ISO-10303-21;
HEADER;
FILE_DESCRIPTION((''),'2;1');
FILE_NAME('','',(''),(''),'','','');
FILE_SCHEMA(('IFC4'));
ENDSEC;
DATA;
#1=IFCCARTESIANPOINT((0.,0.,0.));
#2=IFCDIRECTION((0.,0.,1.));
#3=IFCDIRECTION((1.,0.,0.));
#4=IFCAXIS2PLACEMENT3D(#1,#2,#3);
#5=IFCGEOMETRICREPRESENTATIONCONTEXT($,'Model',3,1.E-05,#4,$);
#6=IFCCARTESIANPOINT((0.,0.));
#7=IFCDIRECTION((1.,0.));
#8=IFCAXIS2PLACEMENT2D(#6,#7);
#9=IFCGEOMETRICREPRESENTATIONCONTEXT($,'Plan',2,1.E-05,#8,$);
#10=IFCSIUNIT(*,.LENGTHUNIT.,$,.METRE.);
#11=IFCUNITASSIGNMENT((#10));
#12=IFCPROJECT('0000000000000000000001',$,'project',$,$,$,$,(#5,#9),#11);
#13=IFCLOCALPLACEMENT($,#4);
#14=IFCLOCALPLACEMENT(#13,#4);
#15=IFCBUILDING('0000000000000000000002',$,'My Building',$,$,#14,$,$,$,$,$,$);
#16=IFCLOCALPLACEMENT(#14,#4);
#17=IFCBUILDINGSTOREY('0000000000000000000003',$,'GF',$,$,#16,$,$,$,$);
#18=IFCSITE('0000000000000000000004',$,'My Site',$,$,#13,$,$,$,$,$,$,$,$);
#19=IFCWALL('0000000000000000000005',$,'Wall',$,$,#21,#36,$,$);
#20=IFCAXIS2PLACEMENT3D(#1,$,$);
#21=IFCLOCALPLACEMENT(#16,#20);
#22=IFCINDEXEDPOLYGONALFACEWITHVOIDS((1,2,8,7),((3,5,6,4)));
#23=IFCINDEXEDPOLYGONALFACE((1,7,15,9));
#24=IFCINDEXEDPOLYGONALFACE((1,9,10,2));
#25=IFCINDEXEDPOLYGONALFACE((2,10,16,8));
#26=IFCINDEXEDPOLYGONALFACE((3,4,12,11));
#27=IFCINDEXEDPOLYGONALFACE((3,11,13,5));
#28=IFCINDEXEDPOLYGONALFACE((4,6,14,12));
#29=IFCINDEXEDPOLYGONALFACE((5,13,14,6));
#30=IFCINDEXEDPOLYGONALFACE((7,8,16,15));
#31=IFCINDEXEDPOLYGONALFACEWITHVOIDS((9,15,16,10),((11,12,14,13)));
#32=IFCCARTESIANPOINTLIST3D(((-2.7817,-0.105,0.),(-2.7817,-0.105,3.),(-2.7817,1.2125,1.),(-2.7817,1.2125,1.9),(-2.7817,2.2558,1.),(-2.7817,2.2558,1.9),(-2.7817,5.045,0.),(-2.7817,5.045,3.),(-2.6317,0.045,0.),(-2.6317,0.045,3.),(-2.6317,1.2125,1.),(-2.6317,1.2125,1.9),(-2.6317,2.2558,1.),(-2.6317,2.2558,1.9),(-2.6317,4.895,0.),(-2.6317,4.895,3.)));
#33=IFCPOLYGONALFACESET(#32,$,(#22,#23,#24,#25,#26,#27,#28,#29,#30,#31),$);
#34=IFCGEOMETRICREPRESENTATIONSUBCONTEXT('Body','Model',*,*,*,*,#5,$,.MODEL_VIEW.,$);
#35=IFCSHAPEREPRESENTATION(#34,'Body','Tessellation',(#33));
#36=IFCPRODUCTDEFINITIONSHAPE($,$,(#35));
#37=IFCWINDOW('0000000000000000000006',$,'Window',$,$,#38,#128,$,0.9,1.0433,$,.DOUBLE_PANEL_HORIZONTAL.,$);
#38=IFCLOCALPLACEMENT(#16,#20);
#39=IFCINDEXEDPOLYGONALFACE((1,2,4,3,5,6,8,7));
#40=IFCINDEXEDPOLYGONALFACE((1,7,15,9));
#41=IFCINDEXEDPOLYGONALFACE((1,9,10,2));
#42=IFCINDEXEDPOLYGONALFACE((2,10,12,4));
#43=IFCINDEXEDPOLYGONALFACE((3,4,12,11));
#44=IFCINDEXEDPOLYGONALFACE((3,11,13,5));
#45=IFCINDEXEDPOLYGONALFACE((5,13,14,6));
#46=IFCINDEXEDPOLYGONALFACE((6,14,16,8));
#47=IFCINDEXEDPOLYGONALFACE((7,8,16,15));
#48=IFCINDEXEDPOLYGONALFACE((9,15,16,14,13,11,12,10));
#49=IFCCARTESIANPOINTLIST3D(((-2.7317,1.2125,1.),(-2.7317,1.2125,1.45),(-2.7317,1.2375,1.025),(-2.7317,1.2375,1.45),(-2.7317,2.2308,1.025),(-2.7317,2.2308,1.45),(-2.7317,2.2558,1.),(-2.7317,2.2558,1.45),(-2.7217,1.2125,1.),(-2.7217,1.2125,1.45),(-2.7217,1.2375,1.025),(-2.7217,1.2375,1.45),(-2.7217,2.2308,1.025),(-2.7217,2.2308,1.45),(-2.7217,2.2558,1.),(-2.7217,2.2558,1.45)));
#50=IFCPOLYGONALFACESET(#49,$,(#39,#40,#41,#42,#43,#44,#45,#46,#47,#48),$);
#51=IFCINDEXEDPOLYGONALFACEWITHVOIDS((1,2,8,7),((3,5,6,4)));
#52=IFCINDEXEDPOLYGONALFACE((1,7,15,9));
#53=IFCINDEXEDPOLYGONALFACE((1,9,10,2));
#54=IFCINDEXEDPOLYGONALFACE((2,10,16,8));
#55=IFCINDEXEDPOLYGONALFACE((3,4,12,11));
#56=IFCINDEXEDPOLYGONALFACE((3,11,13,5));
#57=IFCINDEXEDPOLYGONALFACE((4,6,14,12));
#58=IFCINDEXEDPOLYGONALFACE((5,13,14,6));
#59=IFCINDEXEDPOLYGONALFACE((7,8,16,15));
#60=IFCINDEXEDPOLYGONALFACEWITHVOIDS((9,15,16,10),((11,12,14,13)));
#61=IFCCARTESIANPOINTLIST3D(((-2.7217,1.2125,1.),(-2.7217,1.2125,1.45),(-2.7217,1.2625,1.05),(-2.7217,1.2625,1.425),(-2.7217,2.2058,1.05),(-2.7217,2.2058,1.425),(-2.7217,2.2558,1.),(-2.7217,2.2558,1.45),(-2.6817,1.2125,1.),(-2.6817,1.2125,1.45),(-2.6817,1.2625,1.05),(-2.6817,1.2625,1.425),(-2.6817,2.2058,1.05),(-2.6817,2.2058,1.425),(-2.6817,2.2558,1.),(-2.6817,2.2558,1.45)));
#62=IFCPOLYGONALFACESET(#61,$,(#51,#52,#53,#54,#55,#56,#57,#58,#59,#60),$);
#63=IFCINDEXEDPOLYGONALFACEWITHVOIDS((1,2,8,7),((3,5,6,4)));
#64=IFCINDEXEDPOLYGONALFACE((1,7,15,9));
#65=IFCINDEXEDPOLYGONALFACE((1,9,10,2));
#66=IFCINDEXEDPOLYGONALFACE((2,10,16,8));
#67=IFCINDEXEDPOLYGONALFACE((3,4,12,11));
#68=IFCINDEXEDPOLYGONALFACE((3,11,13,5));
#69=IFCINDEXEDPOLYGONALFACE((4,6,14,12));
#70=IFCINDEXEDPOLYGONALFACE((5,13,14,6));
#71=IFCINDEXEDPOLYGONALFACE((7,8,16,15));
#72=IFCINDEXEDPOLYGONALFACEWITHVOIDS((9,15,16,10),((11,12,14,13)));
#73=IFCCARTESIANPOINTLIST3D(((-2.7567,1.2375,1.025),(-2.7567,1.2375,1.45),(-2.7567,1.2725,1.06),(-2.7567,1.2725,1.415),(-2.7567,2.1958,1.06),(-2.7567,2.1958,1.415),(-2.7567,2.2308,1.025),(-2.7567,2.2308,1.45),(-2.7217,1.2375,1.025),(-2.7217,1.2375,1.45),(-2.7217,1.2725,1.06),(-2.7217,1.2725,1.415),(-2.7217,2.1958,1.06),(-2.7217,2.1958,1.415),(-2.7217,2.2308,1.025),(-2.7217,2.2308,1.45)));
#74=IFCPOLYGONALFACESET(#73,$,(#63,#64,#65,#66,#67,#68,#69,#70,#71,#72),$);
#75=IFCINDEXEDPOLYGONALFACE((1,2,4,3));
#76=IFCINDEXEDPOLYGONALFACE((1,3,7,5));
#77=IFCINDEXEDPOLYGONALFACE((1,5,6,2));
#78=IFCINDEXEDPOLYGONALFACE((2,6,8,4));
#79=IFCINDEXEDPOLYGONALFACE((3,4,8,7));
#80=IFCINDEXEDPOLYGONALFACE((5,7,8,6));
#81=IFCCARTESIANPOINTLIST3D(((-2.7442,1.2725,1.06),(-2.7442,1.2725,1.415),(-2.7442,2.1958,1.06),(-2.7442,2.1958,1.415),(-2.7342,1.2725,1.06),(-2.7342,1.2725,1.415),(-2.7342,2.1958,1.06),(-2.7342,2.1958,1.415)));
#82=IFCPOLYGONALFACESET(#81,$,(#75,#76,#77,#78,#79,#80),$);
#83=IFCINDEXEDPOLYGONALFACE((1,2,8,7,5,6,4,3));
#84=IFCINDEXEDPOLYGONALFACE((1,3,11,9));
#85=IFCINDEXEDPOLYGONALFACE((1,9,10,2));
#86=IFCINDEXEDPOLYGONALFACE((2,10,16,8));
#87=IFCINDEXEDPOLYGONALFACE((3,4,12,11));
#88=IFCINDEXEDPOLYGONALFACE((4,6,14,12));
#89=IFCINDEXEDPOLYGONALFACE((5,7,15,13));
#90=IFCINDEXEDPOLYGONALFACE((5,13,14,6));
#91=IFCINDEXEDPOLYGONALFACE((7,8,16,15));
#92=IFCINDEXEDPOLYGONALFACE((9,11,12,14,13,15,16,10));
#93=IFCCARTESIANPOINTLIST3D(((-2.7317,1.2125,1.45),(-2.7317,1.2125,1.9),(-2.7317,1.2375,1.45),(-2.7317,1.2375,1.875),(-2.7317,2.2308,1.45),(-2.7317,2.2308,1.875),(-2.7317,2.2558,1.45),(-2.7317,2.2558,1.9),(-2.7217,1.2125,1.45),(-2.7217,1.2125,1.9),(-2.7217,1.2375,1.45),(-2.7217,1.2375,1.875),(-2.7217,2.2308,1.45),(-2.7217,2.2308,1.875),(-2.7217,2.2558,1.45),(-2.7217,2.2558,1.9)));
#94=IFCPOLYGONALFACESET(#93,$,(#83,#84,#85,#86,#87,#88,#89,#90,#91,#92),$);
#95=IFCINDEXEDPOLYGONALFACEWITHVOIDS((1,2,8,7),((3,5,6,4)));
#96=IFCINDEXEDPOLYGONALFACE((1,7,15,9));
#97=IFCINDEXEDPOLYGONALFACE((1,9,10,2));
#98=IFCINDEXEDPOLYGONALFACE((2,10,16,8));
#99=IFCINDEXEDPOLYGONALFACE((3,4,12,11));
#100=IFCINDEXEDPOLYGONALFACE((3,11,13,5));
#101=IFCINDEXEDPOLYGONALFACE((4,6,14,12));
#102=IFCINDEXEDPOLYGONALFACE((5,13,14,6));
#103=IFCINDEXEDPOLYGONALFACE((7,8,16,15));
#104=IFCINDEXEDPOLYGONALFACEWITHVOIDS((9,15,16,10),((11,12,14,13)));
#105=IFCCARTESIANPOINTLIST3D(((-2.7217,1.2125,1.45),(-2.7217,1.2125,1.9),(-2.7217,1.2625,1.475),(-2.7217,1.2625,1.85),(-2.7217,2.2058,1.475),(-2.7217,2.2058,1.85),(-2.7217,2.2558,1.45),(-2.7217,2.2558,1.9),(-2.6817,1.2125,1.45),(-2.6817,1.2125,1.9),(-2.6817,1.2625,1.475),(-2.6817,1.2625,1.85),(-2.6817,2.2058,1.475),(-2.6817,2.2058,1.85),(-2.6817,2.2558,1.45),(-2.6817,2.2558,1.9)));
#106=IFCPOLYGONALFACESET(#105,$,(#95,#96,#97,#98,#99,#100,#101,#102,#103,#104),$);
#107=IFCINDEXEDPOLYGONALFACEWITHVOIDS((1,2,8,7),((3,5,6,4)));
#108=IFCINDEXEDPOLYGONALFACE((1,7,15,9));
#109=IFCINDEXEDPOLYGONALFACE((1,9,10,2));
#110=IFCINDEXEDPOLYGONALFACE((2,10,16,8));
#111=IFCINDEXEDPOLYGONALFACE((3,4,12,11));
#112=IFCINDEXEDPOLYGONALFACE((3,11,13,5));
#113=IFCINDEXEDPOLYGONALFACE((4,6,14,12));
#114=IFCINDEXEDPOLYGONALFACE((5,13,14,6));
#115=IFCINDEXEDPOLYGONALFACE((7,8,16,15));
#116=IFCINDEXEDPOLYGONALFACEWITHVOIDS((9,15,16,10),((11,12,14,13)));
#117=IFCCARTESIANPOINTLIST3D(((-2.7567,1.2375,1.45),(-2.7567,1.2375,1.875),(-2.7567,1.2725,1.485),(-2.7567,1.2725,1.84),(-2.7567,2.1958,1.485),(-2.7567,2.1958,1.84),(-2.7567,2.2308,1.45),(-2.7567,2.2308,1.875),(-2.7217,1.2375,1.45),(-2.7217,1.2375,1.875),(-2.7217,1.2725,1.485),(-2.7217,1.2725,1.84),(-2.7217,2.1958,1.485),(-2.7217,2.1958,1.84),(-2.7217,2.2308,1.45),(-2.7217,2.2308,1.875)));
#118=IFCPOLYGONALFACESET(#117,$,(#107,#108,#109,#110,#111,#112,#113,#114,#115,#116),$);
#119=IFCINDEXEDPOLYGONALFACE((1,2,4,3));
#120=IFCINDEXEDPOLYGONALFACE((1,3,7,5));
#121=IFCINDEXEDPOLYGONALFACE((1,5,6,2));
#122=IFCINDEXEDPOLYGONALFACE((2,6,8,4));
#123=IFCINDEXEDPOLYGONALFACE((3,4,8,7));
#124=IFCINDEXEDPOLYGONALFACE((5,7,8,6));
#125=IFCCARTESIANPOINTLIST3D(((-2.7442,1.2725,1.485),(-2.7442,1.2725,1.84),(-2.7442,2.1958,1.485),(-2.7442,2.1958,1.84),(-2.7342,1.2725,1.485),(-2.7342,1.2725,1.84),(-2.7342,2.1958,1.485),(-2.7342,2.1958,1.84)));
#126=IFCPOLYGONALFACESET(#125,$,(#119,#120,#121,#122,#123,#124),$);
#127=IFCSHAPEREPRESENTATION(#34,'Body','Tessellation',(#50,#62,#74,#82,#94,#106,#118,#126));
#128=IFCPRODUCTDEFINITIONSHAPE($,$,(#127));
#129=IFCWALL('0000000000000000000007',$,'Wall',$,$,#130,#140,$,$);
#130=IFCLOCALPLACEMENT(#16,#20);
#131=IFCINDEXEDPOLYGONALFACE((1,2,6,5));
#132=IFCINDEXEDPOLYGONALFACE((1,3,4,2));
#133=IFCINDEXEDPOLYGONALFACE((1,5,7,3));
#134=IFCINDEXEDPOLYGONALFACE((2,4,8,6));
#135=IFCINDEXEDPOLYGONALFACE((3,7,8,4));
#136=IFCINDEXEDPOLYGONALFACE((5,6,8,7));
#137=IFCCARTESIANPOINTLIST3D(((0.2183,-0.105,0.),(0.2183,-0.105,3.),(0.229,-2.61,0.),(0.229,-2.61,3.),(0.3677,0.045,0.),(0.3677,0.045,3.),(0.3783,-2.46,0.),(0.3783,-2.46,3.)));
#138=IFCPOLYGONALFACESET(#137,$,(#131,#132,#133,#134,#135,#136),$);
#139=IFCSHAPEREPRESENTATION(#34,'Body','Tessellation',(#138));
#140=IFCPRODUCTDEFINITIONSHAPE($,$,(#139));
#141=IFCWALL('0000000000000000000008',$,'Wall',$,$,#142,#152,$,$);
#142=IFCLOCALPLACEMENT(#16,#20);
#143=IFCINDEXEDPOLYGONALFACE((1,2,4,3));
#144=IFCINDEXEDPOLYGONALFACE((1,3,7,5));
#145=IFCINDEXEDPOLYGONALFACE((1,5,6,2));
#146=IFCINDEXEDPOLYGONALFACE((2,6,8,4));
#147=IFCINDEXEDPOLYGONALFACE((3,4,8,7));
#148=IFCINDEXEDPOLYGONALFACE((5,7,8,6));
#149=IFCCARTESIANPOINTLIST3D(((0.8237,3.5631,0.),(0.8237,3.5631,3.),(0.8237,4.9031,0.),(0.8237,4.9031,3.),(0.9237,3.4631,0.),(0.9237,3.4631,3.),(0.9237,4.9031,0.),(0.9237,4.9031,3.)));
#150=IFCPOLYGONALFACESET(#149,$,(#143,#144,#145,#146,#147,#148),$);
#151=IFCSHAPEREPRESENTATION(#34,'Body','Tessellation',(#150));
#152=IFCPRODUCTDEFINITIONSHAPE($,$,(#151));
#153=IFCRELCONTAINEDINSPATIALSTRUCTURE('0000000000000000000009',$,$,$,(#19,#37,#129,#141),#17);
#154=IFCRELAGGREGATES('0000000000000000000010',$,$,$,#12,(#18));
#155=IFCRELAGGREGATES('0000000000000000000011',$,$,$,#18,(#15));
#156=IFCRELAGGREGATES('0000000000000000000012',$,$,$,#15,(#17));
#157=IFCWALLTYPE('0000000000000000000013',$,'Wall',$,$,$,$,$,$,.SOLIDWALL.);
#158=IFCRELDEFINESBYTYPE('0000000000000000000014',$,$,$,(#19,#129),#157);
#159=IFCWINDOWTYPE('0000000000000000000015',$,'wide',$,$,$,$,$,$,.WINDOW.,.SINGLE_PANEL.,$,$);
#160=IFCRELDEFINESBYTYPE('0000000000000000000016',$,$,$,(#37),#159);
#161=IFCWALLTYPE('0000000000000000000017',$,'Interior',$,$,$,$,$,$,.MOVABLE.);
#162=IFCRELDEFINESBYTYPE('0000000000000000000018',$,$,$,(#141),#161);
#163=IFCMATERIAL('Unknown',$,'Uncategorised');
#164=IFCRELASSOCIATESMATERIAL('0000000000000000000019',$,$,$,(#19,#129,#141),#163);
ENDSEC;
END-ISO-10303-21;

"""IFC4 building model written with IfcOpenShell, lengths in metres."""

from ifc_helpers import new_model, entity, si_unit, frame, origin_with_axes, origin_2d_with_axis, place, context, subcontext, project, spatial, line, indexed_curve, outline, extrude, shape, source, transform, mapped, material, type_object, type_shapes, element, fill, save


model = new_model("IFC4")

# Units and contexts
model_context = context("Model", 3, precision=1e-05, world=origin_with_axes())
plan_context = context("Plan", 2, precision=1e-05, world=origin_2d_with_axis())
body_context_1 = subcontext(model_context, "Body", "Model", "MODEL_VIEW")
body_context_2 = subcontext(plan_context, "Body", "Plan", "PLAN_VIEW")
ifc_project = project(units=[si_unit("LENGTHUNIT", "METRE")], contexts=[model_context, plan_context])

# Site, building, storey
site_placement = place(None, origin_with_axes())
site = spatial("IfcSite", under=ifc_project, at=site_placement, Name="My Site")
building_placement = place(site_placement, origin_with_axes())
building = spatial("IfcBuilding", under=site, at=building_placement, Name="My Building")
storey_placement = place(building_placement, origin_with_axes())
storey = spatial("IfcBuildingStorey", under=building, at=storey_placement, Name="GF")

# Shared definitions
ifc_material = material(Name="Unknown", Category="Uncategorised")

# Shared definitions
wall_type_1 = type_object("IfcWallType", Name="Wall", PredefinedType="SOLIDWALL")
shared_shape_1 = source(origin_with_axes(), body_context_1, "Body", "SweptSolid", [
    extrude(outline(indexed_curve([(0.0, 0.0), (1.0433, 0.0), (1.0433, 0.9), (0.0, 0.9)], segments=[line(1, 2, 3, 4, 1)])), frame((0.0, -0.6, 0.0), z_axis=(0.0, -1.0, 0.0), x_axis=(1.0, 0.0, 0.0)), (0.0, 0.0, -1.0), 1.2),
])
window_type_1 = type_object("IfcWindowType", Name="wide", PartitioningType="SINGLE_PANEL", PredefinedType="WINDOW")
shared_shape_2 = source(origin_with_axes(), body_context_1, "Body", "SweptSolid", [
    extrude(outline(indexed_curve([(1.0433, 0.45), (1.0433, 0.0), (0.0, 0.0), (0.0, 0.45), (0.025, 0.45), (0.025, 0.025), (1.0183, 0.025), (1.0183, 0.45)], segments=[line(1, 2, 3, 4, 5, 6, 7, 8, 1)])), frame((0.0, 0.09, 0.0), z_axis=(0.0, -1.0, 0.0), x_axis=(1.0, 0.0, 0.0)), (0.0, 0.0, -1.0), 0.01),
    extrude(outline(indexed_curve([(0.0, 0.0), (1.0433, 0.0), (1.0433, 0.45), (0.0, 0.45)], segments=[line(1, 2, 3, 4, 1)]), holes=[indexed_curve([(0.05, 0.05), (0.9933, 0.05), (0.9933, 0.425), (0.05, 0.425)], segments=[line(1, 2, 3, 4, 1)])]), frame((0.0, 0.05, 0.0), z_axis=(0.0, -1.0, 0.0), x_axis=(1.0, 0.0, 0.0)), (0.0, 0.0, -1.0), 0.04),
    extrude(outline(indexed_curve([(0.0, 0.0), (0.9933, 0.0), (0.9933, 0.425), (0.0, 0.425)], segments=[line(1, 2, 3, 4, 1)]), holes=[indexed_curve([(0.035, 0.035), (0.9583, 0.035), (0.9583, 0.39), (0.035, 0.39)], segments=[line(1, 2, 3, 4, 1)])]), frame((0.025, 0.09, 0.025), z_axis=(0.0, -1.0, 0.0), x_axis=(1.0, 0.0, 0.0)), (0.0, 0.0, -1.0), 0.035),
    extrude(outline(indexed_curve([(0.035, 0.035), (0.9583, 0.035), (0.9583, 0.39), (0.035, 0.39)], segments=[line(1, 2, 3, 4, 1)])), frame((0.025, 0.1025, 0.025), z_axis=(0.0, -1.0, 0.0), x_axis=(1.0, 0.0, 0.0)), (0.0, 0.0, -1.0), 0.01),
    extrude(outline(indexed_curve([(0.0, 0.0), (0.0, 0.45), (1.0433, 0.45), (1.0433, 0.0), (1.0183, 0.0), (1.0183, 0.425), (0.025, 0.425), (0.025, 0.0)], segments=[line(1, 2, 3, 4, 5, 6, 7, 8, 1)])), frame((0.0, 0.09, 0.45), z_axis=(0.0, -1.0, 0.0), x_axis=(1.0, 0.0, 0.0)), (0.0, 0.0, -1.0), 0.01),
    extrude(outline(indexed_curve([(0.0, 0.0), (1.0433, 0.0), (1.0433, 0.45), (0.0, 0.45)], segments=[line(1, 2, 3, 4, 1)]), holes=[indexed_curve([(0.05, 0.025), (0.9933, 0.025), (0.9933, 0.4), (0.05, 0.4)], segments=[line(1, 2, 3, 4, 1)])]), frame((0.0, 0.05, 0.45), z_axis=(0.0, -1.0, 0.0), x_axis=(1.0, 0.0, 0.0)), (0.0, 0.0, -1.0), 0.04),
    extrude(outline(indexed_curve([(0.0, 0.0), (0.9933, 0.0), (0.9933, 0.425), (0.0, 0.425)], segments=[line(1, 2, 3, 4, 1)]), holes=[indexed_curve([(0.035, 0.035), (0.9583, 0.035), (0.9583, 0.39), (0.035, 0.39)], segments=[line(1, 2, 3, 4, 1)])]), frame((0.025, 0.09, 0.45), z_axis=(0.0, -1.0, 0.0), x_axis=(1.0, 0.0, 0.0)), (0.0, 0.0, -1.0), 0.035),
    extrude(outline(indexed_curve([(0.035, 0.035), (0.9583, 0.035), (0.9583, 0.39), (0.035, 0.39)], segments=[line(1, 2, 3, 4, 1)])), frame((0.025, 0.1025, 0.45), z_axis=(0.0, -1.0, 0.0), x_axis=(1.0, 0.0, 0.0)), (0.0, 0.0, -1.0), 0.01),
])
shared_shape_3 = source(origin_with_axes(), body_context_2, "Body", "Curve2D", [
    entity("IfcIndexedPolyCurve", entity("IfcCartesianPointList2D", [[0.05, 0.05], [0.9933, 0.05]])),
    entity("IfcIndexedPolyCurve", entity("IfcCartesianPointList2D", [[0.0, 0.1], [0.025, 0.1], [0.025, 0.09], [0.05, 0.09], [0.05, 0.05], [0.0, 0.05]]), [entity("IfcLineIndex", [1, 2, 3, 4, 5, 6, 1])]),
    entity("IfcIndexedPolyCurve", entity("IfcCartesianPointList2D", [[1.0433, 0.1], [1.0183, 0.1], [1.0183, 0.09], [0.9933, 0.09], [0.9933, 0.05], [1.0433, 0.05]]), [entity("IfcLineIndex", [1, 2, 3, 4, 5, 6, 1])]),
    entity("IfcIndexedPolyCurve", entity("IfcCartesianPointList2D", [[0.025, 0.09], [0.06, 0.09], [0.06, 0.125], [0.025, 0.125]]), [entity("IfcLineIndex", [1, 2, 3, 4, 1])]),
    entity("IfcIndexedPolyCurve", entity("IfcCartesianPointList2D", [[1.0183, 0.09], [0.9833, 0.09], [0.9833, 0.125], [1.0183, 0.125]]), [entity("IfcLineIndex", [1, 2, 3, 4, 1])]),
    entity("IfcIndexedPolyCurve", entity("IfcCartesianPointList2D", [[0.06, 0.09], [0.9833, 0.09]])),
    entity("IfcIndexedPolyCurve", entity("IfcCartesianPointList2D", [[0.06, 0.125], [0.9833, 0.125]])),
    entity("IfcIndexedPolyCurve", entity("IfcCartesianPointList2D", [[0.06, 0.1075], [0.9833, 0.1075]])),
])
type_shapes(window_type_1, [shared_shape_2, shared_shape_3])

# Wall, opening, window
wall_1_placement = place(storey_placement, frame((-2.7817, 5.045, 0.0), z_axis=(0.0, 0.0, 1.0), x_axis=(0.0, -1.0, 0.0)))
wall_1 = element("IfcWall", 1, at=wall_1_placement, inside=storey, type_object=wall_type_1, material=ifc_material, Name="Wall", context=body_context_1, shape_type="SweptSolid", body=[
    extrude(outline(indexed_curve([(0.0, 0.0), (0.15, 0.15), (5.0, 0.15), (5.15, 0.0)], segments=[line(1, 2, 3, 4, 1)])), origin_with_axes(), (0.0, 0.0, 1.0), 3.0),
])
opening_1_placement = place(wall_1_placement, frame((3.8324, 0.15, 1.0), z_axis=(0.0, 0.0, 1.0), x_axis=(-1.0, 0.0, 0.0)))
opening_1 = element("IfcOpeningElement", 2, at=opening_1_placement, cuts=wall_1, PredefinedType="OPENING", context=body_context_1, shape_type="MappedRepresentation", body=[
    mapped(shared_shape_1, transform((0.0, 0.0, 0.0), x_axis=(1.0, 0.0, 0.0), y_axis=(0.0, 1.0, 0.0), z_axis=(0.0, 0.0, 1.0), scale=1.0)),
])
window_1_placement = place(opening_1_placement, frame((0.0, 0.0, 0.0), z_axis=(0.0, 0.0, 1.0), x_axis=(1.0, 0.0, 0.0)))
window_1 = element("IfcWindow", 3, at=window_1_placement, inside=storey, type_object=window_type_1, Name="Window", OverallHeight=0.9, OverallWidth=1.0433, PartitioningType="DOUBLE_PANEL_HORIZONTAL", shapes=[
    shape(body_context_1, "Body", "MappedRepresentation", [mapped(shared_shape_2, transform((0.0, 0.0, 0.0), x_axis=(1.0, 0.0, 0.0), y_axis=(0.0, 1.0, 0.0), z_axis=(0.0, 0.0, 1.0), scale=1.0))]),
    shape(body_context_2, "Body", "MappedRepresentation", [mapped(shared_shape_3, transform((0.0, 0.0, 0.0), x_axis=(1.0, 0.0, 0.0), y_axis=(0.0, 1.0, 0.0), z_axis=(0.0, 0.0, 1.0), scale=1.0))]),
])
fill(opening_1, window_1)

# Walls
wall_2_placement = place(storey_placement, frame((0.2183, -0.105, 0.0), z_axis=(0.0, 0.0, 1.0), x_axis=(0.004245, -0.999991, 0.0)))
element("IfcWall", 4, at=wall_2_placement, inside=storey, type_object=wall_type_1, material=ifc_material, Name="Wall", context=body_context_1, shape_type="SweptSolid", body=[
    extrude(outline(indexed_curve([(0.0, 0.0), (-0.1494, 0.15), (2.3557, 0.15), (2.505, 0.0)], segments=[line(1, 2, 3, 4, 1)])), origin_with_axes(), (0.0, 0.0, 1.0), 3.0),
])
wall_type_2 = type_object("IfcWallType", Name="Interior", PredefinedType="MOVABLE")
wall_3_placement = place(storey_placement, frame((0.8237, 4.9031, 0.0), z_axis=(0.0, 0.0, 1.0), x_axis=(0.0, -1.0, 0.0)))
element("IfcWall", 5, at=wall_3_placement, inside=storey, type_object=wall_type_2, material=ifc_material, Name="Wall", context=body_context_1, shape_type="SweptSolid", body=[
    extrude(outline(indexed_curve([(0.0, 0.0), (0.0, 0.1), (1.44, 0.1), (1.34, 0.0)], segments=[line(1, 2, 3, 4, 1)])), origin_with_axes(), (0.0, 0.0, 1.0), 3.0),
])

save(model, "model.ifc")
